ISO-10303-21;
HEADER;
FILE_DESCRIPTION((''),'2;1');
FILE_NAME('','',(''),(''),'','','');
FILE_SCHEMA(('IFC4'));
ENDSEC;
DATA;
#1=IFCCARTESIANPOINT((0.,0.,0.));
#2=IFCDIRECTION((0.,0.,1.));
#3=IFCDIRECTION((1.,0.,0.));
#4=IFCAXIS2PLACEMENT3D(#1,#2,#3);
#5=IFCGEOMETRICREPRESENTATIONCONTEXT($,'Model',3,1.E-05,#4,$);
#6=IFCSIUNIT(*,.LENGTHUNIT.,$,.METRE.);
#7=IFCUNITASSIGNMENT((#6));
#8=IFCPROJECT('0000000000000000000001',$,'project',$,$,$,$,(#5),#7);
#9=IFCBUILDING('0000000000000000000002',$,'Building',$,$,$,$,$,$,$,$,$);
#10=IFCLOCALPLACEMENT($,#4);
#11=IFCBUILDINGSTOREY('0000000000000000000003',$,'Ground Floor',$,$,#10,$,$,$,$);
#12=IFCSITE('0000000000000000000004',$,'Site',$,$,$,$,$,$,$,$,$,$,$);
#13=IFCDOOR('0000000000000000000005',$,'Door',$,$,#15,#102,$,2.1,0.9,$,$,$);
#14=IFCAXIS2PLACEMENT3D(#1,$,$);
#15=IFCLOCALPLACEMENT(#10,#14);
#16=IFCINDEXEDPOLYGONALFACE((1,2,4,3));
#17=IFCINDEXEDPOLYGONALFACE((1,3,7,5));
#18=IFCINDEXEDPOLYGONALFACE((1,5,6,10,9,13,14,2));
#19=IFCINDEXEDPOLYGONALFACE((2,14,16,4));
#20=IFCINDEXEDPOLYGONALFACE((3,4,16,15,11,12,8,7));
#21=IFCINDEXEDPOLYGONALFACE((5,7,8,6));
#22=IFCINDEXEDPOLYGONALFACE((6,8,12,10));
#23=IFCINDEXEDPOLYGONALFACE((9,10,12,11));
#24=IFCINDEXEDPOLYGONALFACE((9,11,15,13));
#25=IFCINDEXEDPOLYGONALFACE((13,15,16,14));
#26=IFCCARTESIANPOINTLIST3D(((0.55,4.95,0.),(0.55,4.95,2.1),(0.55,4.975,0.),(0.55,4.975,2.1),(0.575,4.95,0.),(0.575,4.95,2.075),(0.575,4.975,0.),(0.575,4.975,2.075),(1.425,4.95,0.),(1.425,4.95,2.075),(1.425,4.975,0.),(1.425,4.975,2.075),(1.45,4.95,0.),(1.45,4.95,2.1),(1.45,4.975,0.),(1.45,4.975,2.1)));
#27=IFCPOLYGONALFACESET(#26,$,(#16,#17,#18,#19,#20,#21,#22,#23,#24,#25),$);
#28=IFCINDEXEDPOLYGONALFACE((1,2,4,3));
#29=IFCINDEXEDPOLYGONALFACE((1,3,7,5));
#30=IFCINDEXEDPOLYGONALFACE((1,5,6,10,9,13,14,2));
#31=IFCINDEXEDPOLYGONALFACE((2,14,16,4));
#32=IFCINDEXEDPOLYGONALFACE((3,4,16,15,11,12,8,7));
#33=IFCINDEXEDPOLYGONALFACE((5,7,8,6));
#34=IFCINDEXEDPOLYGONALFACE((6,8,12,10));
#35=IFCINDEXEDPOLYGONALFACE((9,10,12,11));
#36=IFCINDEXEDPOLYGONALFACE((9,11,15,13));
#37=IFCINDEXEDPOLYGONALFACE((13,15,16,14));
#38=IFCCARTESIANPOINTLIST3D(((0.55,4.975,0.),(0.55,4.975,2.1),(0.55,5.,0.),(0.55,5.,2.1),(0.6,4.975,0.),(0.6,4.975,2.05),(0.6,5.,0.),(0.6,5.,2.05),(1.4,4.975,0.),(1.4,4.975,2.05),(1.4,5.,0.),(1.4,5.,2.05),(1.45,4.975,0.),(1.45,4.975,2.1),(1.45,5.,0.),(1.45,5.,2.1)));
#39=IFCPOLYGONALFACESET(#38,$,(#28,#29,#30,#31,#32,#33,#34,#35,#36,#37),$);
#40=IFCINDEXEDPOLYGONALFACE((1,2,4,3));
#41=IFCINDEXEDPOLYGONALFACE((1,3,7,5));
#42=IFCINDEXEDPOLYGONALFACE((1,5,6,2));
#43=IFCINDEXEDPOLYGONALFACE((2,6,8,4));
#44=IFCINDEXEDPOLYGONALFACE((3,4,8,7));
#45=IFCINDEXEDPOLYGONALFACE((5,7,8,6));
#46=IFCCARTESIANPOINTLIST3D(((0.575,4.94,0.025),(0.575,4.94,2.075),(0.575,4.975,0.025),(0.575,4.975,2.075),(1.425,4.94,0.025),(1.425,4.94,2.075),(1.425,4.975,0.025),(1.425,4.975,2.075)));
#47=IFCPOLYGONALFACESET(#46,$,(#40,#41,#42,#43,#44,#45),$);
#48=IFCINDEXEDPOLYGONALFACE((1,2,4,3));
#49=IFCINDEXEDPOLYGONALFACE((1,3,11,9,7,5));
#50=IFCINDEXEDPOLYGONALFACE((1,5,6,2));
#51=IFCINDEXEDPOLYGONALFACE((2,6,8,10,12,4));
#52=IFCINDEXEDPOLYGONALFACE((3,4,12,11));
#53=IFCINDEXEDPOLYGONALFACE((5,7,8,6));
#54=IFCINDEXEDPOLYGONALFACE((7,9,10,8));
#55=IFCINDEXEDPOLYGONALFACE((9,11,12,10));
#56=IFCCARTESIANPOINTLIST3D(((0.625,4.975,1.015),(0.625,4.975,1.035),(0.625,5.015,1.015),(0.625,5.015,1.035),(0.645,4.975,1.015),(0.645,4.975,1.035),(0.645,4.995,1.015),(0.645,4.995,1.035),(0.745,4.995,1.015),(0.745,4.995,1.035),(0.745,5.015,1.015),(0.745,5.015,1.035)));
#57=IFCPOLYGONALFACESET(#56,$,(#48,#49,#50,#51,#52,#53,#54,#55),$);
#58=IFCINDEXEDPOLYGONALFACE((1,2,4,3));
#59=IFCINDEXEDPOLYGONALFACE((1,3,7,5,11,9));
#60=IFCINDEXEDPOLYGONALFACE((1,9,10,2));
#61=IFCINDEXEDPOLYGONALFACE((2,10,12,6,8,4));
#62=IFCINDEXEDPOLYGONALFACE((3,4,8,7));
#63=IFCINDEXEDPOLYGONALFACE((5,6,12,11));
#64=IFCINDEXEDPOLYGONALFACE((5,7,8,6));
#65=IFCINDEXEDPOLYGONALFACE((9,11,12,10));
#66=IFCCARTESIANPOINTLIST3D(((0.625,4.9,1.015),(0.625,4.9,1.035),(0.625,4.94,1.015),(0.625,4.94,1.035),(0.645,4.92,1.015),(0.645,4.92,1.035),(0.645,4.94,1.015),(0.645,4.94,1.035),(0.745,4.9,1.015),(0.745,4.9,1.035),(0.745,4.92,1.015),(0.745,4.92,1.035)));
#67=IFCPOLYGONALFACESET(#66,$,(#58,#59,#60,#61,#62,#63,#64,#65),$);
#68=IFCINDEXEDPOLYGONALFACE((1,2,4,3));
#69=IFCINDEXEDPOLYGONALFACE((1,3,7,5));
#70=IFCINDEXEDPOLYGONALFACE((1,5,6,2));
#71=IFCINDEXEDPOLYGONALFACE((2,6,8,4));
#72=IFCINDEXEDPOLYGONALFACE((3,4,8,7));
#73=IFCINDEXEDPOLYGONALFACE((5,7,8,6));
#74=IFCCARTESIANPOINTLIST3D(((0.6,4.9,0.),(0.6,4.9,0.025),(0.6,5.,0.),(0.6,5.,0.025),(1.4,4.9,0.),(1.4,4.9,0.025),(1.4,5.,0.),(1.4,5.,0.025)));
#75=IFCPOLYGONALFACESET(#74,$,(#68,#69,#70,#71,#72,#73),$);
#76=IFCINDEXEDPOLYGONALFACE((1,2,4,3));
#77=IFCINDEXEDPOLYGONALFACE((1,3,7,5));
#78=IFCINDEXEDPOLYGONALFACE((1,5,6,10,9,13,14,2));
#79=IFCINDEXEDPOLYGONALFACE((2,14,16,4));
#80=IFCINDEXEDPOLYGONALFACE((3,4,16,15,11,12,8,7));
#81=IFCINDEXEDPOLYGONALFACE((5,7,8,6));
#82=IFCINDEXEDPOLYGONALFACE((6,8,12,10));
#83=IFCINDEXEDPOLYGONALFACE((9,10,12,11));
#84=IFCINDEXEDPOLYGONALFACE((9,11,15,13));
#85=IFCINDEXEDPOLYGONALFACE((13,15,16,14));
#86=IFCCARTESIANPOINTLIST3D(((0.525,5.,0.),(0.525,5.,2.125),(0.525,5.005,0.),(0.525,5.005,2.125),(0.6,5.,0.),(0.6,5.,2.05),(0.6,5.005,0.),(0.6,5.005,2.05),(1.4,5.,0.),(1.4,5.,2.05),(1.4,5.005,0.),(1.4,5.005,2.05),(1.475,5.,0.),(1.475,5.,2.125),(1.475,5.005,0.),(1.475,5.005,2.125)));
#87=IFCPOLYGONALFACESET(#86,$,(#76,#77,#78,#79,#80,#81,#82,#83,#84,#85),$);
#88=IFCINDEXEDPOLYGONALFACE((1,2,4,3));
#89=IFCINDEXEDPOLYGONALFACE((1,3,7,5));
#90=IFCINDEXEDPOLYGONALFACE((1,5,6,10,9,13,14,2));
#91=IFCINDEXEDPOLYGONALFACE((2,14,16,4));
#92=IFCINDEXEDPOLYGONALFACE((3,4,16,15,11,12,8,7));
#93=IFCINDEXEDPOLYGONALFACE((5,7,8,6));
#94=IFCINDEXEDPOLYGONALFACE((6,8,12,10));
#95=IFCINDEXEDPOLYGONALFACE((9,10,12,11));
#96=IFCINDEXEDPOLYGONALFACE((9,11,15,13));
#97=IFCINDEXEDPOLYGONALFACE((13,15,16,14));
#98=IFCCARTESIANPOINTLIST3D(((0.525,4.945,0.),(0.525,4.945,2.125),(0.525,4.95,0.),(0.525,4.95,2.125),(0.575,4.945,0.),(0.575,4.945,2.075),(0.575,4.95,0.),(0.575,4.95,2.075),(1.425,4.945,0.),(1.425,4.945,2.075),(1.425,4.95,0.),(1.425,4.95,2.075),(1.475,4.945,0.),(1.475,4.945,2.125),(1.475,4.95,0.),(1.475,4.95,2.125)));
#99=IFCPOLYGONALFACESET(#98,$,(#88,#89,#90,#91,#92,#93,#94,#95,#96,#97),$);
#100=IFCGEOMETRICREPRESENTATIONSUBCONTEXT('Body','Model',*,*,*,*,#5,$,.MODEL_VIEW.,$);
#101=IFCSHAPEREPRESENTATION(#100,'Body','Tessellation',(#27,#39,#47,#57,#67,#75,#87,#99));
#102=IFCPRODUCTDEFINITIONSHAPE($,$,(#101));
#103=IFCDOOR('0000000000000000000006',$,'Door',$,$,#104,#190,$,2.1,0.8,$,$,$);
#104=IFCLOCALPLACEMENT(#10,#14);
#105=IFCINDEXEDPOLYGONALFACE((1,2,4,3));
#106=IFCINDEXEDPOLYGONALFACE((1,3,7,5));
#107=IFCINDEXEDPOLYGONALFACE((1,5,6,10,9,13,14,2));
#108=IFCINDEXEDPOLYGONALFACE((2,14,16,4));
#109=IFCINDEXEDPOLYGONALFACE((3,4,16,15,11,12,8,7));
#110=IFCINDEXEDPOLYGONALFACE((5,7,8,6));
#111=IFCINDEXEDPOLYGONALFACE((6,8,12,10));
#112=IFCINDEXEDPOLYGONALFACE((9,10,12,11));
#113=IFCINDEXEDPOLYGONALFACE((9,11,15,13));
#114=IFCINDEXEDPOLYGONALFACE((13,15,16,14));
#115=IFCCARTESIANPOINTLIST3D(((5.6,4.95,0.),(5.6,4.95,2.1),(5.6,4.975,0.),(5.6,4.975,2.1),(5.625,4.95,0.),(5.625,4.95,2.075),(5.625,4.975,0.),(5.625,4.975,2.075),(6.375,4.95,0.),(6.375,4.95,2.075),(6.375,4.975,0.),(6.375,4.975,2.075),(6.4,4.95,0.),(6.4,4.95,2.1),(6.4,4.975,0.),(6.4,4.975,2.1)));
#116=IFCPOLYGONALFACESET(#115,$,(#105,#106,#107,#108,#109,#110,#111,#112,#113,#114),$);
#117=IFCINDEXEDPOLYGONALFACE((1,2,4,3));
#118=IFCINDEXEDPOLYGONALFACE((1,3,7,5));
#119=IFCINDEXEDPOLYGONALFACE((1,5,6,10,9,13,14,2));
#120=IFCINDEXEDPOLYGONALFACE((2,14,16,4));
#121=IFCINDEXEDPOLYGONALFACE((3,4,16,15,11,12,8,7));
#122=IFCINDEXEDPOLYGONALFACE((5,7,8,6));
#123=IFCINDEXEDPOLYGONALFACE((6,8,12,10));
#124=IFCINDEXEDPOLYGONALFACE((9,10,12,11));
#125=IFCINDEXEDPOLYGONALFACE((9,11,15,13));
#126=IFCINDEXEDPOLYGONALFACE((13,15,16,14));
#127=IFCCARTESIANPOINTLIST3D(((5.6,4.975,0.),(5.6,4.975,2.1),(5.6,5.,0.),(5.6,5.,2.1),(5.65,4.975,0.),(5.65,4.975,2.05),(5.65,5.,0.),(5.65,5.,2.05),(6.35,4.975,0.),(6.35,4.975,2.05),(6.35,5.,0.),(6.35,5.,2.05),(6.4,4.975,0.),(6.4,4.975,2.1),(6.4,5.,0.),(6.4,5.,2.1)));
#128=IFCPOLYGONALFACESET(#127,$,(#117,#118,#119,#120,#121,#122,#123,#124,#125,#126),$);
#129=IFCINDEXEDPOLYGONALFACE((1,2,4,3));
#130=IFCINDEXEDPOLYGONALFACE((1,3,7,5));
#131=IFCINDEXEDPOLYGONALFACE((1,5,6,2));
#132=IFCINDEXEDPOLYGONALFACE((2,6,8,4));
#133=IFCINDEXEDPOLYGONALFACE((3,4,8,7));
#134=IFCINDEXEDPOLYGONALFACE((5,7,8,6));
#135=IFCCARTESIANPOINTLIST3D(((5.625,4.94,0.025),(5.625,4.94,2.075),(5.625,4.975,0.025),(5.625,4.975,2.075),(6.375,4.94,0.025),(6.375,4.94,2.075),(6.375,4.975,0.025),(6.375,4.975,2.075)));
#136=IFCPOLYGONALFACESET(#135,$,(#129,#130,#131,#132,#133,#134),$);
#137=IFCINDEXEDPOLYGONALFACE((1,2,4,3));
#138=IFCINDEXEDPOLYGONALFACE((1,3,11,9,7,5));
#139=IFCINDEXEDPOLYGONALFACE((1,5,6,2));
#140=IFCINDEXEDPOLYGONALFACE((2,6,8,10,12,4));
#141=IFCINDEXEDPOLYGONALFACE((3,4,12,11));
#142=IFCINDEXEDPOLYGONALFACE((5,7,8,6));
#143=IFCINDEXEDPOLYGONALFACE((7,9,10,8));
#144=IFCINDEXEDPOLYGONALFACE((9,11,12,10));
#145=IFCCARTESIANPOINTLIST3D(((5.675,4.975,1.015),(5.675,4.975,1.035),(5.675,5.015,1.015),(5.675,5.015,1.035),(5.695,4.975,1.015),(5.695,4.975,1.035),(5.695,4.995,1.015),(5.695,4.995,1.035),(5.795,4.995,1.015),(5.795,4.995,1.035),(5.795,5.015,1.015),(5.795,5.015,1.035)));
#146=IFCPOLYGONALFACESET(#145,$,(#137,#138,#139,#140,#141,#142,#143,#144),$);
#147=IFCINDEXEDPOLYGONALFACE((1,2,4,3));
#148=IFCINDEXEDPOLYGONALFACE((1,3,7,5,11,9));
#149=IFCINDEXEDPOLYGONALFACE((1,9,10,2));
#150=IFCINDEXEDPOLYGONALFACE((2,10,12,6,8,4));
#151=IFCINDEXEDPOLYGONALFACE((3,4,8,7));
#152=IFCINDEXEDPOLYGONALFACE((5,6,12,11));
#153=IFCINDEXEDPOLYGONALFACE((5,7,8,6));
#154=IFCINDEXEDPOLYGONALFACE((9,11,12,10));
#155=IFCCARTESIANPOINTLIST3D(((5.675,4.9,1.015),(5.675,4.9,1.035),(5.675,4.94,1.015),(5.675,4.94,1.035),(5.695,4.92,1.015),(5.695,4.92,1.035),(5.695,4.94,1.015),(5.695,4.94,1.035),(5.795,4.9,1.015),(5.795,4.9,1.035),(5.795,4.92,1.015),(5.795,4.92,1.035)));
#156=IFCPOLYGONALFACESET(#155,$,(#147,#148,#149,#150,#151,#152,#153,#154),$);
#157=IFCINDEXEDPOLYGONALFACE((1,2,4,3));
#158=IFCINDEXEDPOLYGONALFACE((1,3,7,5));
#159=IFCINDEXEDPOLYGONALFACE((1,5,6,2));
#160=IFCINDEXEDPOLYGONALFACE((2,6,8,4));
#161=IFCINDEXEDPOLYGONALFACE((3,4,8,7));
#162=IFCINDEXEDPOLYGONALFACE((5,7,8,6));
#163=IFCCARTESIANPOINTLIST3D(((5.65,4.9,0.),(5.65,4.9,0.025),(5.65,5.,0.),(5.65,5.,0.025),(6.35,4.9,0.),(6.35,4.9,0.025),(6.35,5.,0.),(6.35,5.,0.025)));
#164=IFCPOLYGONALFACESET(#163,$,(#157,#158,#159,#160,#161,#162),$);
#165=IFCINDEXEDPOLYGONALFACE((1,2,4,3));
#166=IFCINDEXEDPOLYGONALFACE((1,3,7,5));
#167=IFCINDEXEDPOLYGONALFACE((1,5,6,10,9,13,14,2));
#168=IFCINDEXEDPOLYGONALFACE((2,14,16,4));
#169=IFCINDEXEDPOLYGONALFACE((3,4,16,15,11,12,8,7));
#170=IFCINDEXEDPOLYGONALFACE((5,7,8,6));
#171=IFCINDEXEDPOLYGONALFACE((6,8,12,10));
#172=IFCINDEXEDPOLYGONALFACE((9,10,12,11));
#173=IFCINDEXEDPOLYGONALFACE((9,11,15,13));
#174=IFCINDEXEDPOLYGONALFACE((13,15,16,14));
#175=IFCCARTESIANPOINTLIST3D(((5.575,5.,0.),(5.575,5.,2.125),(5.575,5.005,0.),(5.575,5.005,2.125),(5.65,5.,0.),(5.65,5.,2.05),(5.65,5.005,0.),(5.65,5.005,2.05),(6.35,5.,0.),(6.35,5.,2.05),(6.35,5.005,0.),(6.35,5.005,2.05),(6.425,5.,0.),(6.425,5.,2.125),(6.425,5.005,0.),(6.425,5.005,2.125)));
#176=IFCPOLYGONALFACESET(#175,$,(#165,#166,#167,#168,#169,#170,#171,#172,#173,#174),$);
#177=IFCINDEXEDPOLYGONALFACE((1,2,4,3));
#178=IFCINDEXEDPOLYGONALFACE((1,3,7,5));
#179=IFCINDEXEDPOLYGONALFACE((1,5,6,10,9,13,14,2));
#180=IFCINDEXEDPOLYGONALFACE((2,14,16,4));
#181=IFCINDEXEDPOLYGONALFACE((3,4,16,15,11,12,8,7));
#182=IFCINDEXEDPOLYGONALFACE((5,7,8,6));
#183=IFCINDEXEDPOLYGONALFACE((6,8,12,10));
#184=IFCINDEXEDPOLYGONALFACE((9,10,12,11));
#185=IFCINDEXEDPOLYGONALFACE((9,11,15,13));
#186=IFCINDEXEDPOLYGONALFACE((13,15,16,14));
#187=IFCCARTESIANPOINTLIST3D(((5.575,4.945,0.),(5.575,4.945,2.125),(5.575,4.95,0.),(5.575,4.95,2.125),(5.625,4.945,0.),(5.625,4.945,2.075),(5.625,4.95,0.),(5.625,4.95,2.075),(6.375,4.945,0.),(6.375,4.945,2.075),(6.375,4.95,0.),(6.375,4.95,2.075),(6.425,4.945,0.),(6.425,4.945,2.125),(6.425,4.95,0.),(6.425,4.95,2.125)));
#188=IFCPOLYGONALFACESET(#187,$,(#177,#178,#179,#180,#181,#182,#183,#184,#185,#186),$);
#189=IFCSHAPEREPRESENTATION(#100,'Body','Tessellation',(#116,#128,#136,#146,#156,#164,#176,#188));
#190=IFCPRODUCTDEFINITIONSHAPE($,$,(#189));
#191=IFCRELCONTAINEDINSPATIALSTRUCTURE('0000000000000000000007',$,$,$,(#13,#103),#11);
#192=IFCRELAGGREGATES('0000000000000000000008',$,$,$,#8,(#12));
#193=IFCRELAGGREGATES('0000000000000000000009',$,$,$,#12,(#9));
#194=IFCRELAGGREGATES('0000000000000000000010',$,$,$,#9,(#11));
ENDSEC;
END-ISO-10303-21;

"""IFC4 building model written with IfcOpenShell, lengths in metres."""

from ifc_helpers import new_model, si_unit, frame, origin_with_axes, place, context, subcontext, project, spatial, line, indexed_curve, outline, extrude, element, save


model = new_model("IFC4")

# Units and contexts
model_context = context("Model", 3, precision=1e-05, world=origin_with_axes())
body_context = subcontext(model_context, "Body", "Model", "MODEL_VIEW")
ifc_project = project(units=[si_unit("LENGTHUNIT", "METRE")], contexts=[model_context])

# Site, building, storey
site = spatial("IfcSite", under=ifc_project, Name="Site")
building = spatial("IfcBuilding", under=site, Name="Building")
storey_placement = place(None, origin_with_axes())
storey = spatial("IfcBuildingStorey", under=building, at=storey_placement, Name="Ground Floor")

# Doors
door_1_placement = place(storey_placement, frame((1.45, 5.0, 0.0), z_axis=(0.0, 0.0, 1.0), x_axis=(-1.0, 0.0, 0.0)))
element("IfcDoor", 1, at=door_1_placement, inside=storey, Name="Door", OverallHeight=2.1, OverallWidth=0.9, context=body_context, shape_type="SweptSolid", body=[
    extrude(outline(indexed_curve([(0.0, 0.0), (0.0, 2.1), (0.9, 2.1), (0.9, 0.0), (0.875, 0.0), (0.875, 2.075), (0.025, 2.075), (0.025, 0.0)], segments=[line(1, 2, 3, 4, 5, 6, 7, 8, 1)])), frame((0.0, 0.025, 0.0), z_axis=(0.0, -1.0, 0.0), x_axis=(1.0, 0.0, 0.0)), (0.0, 0.0, -1.0), 0.025),
    extrude(outline(indexed_curve([(0.0, 0.0), (0.0, 2.1), (0.9, 2.1), (0.9, 0.0), (0.85, 0.0), (0.85, 2.05), (0.05, 2.05), (0.05, 0.0)], segments=[line(1, 2, 3, 4, 5, 6, 7, 8, 1)])), frame((0.0, 0.0, 0.0), z_axis=(0.0, -1.0, 0.0), x_axis=(1.0, 0.0, 0.0)), (0.0, 0.0, -1.0), 0.025),
    extrude(outline(indexed_curve([(0.0, 0.0), (0.85, 0.0), (0.85, 0.035), (0.0, 0.035)], segments=[line(1, 2, 3, 4, 1)])), frame((0.025, 0.025, 0.025), z_axis=(0.0, 0.0, 1.0), x_axis=(1.0, 0.0, 0.0)), (0.0, 0.0, 1.0), 2.05),
    extrude(outline(indexed_curve([(0.0, 0.0), (0.0, -0.04), (-0.12, -0.04), (-0.12, -0.02), (-0.02, -0.02), (-0.02, 0.0)], segments=[line(1, 2, 3, 4, 5, 6, 1)])), frame((0.825, 0.025, 1.015), z_axis=(0.0, 0.0, 1.0), x_axis=(1.0, 0.0, 0.0)), (0.0, 0.0, 1.0), 0.02),
    extrude(outline(indexed_curve([(0.0, 0.0), (0.0, 0.04), (-0.12, 0.04), (-0.12, 0.02), (-0.02, 0.02), (-0.02, 0.0)], segments=[line(1, 2, 3, 4, 5, 6, 1)])), frame((0.825, 0.06, 1.015), z_axis=(0.0, 0.0, 1.0), x_axis=(1.0, 0.0, 0.0)), (0.0, 0.0, 1.0), 0.02),
    extrude(outline(indexed_curve([(0.0, 0.0), (0.8, 0.0), (0.8, 0.1), (0.0, 0.1)], segments=[line(1, 2, 3, 4, 1)])), frame((0.05, 0.0, 0.0), z_axis=(0.0, 0.0, 1.0), x_axis=(1.0, 0.0, 0.0)), (0.0, 0.0, 1.0), 0.025),
    extrude(outline(indexed_curve([(0.0, 0.0), (0.0, 2.125), (0.95, 2.125), (0.95, 0.0), (0.875, 0.0), (0.875, 2.05), (0.075, 2.05), (0.075, 0.0)], segments=[line(1, 2, 3, 4, 5, 6, 7, 8, 1)])), frame((-0.025, -0.005, 0.0), z_axis=(0.0, -1.0, 0.0), x_axis=(1.0, 0.0, 0.0)), (0.0, 0.0, -1.0), 0.005),
    extrude(outline(indexed_curve([(0.0, 0.0), (0.0, 2.125), (0.95, 2.125), (0.95, 0.0), (0.9, 0.0), (0.9, 2.075), (0.05, 2.075), (0.05, 0.0)], segments=[line(1, 2, 3, 4, 5, 6, 7, 8, 1)])), frame((-0.025, 0.05, 0.0), z_axis=(0.0, -1.0, 0.0), x_axis=(1.0, 0.0, 0.0)), (0.0, 0.0, -1.0), 0.005),
])
door_2_placement = place(storey_placement, frame((6.4, 5.0, 0.0), z_axis=(0.0, 0.0, 1.0), x_axis=(-1.0, 0.0, 0.0)))
element("IfcDoor", 2, at=door_2_placement, inside=storey, Name="Door", OverallHeight=2.1, OverallWidth=0.8, context=body_context, shape_type="SweptSolid", body=[
    extrude(outline(indexed_curve([(0.0, 0.0), (0.0, 2.1), (0.8, 2.1), (0.8, 0.0), (0.775, 0.0), (0.775, 2.075), (0.025, 2.075), (0.025, 0.0)], segments=[line(1, 2, 3, 4, 5, 6, 7, 8, 1)])), frame((0.0, 0.025, 0.0), z_axis=(0.0, -1.0, 0.0), x_axis=(1.0, 0.0, 0.0)), (0.0, 0.0, -1.0), 0.025),
    extrude(outline(indexed_curve([(0.0, 0.0), (0.0, 2.1), (0.8, 2.1), (0.8, 0.0), (0.75, 0.0), (0.75, 2.05), (0.05, 2.05), (0.05, 0.0)], segments=[line(1, 2, 3, 4, 5, 6, 7, 8, 1)])), frame((0.0, 0.0, 0.0), z_axis=(0.0, -1.0, 0.0), x_axis=(1.0, 0.0, 0.0)), (0.0, 0.0, -1.0), 0.025),
    extrude(outline(indexed_curve([(0.0, 0.0), (0.75, 0.0), (0.75, 0.035), (0.0, 0.035)], segments=[line(1, 2, 3, 4, 1)])), frame((0.025, 0.025, 0.025), z_axis=(0.0, 0.0, 1.0), x_axis=(1.0, 0.0, 0.0)), (0.0, 0.0, 1.0), 2.05),
    extrude(outline(indexed_curve([(0.0, 0.0), (0.0, -0.04), (-0.12, -0.04), (-0.12, -0.02), (-0.02, -0.02), (-0.02, 0.0)], segments=[line(1, 2, 3, 4, 5, 6, 1)])), frame((0.725, 0.025, 1.015), z_axis=(0.0, 0.0, 1.0), x_axis=(1.0, 0.0, 0.0)), (0.0, 0.0, 1.0), 0.02),
    extrude(outline(indexed_curve([(0.0, 0.0), (0.0, 0.04), (-0.12, 0.04), (-0.12, 0.02), (-0.02, 0.02), (-0.02, 0.0)], segments=[line(1, 2, 3, 4, 5, 6, 1)])), frame((0.725, 0.06, 1.015), z_axis=(0.0, 0.0, 1.0), x_axis=(1.0, 0.0, 0.0)), (0.0, 0.0, 1.0), 0.02),
    extrude(outline(indexed_curve([(0.0, 0.0), (0.7, 0.0), (0.7, 0.1), (0.0, 0.1)], segments=[line(1, 2, 3, 4, 1)])), frame((0.05, 0.0, 0.0), z_axis=(0.0, 0.0, 1.0), x_axis=(1.0, 0.0, 0.0)), (0.0, 0.0, 1.0), 0.025),
    extrude(outline(indexed_curve([(0.0, 0.0), (0.0, 2.125), (0.85, 2.125), (0.85, 0.0), (0.775, 0.0), (0.775, 2.05), (0.075, 2.05), (0.075, 0.0)], segments=[line(1, 2, 3, 4, 5, 6, 7, 8, 1)])), frame((-0.025, -0.005, 0.0), z_axis=(0.0, -1.0, 0.0), x_axis=(1.0, 0.0, 0.0)), (0.0, 0.0, -1.0), 0.005),
    extrude(outline(indexed_curve([(0.0, 0.0), (0.0, 2.125), (0.85, 2.125), (0.85, 0.0), (0.8, 0.0), (0.8, 2.075), (0.05, 2.075), (0.05, 0.0)], segments=[line(1, 2, 3, 4, 5, 6, 7, 8, 1)])), frame((-0.025, 0.05, 0.0), z_axis=(0.0, -1.0, 0.0), x_axis=(1.0, 0.0, 0.0)), (0.0, 0.0, -1.0), 0.005),
])

save(model, "model.ifc")
